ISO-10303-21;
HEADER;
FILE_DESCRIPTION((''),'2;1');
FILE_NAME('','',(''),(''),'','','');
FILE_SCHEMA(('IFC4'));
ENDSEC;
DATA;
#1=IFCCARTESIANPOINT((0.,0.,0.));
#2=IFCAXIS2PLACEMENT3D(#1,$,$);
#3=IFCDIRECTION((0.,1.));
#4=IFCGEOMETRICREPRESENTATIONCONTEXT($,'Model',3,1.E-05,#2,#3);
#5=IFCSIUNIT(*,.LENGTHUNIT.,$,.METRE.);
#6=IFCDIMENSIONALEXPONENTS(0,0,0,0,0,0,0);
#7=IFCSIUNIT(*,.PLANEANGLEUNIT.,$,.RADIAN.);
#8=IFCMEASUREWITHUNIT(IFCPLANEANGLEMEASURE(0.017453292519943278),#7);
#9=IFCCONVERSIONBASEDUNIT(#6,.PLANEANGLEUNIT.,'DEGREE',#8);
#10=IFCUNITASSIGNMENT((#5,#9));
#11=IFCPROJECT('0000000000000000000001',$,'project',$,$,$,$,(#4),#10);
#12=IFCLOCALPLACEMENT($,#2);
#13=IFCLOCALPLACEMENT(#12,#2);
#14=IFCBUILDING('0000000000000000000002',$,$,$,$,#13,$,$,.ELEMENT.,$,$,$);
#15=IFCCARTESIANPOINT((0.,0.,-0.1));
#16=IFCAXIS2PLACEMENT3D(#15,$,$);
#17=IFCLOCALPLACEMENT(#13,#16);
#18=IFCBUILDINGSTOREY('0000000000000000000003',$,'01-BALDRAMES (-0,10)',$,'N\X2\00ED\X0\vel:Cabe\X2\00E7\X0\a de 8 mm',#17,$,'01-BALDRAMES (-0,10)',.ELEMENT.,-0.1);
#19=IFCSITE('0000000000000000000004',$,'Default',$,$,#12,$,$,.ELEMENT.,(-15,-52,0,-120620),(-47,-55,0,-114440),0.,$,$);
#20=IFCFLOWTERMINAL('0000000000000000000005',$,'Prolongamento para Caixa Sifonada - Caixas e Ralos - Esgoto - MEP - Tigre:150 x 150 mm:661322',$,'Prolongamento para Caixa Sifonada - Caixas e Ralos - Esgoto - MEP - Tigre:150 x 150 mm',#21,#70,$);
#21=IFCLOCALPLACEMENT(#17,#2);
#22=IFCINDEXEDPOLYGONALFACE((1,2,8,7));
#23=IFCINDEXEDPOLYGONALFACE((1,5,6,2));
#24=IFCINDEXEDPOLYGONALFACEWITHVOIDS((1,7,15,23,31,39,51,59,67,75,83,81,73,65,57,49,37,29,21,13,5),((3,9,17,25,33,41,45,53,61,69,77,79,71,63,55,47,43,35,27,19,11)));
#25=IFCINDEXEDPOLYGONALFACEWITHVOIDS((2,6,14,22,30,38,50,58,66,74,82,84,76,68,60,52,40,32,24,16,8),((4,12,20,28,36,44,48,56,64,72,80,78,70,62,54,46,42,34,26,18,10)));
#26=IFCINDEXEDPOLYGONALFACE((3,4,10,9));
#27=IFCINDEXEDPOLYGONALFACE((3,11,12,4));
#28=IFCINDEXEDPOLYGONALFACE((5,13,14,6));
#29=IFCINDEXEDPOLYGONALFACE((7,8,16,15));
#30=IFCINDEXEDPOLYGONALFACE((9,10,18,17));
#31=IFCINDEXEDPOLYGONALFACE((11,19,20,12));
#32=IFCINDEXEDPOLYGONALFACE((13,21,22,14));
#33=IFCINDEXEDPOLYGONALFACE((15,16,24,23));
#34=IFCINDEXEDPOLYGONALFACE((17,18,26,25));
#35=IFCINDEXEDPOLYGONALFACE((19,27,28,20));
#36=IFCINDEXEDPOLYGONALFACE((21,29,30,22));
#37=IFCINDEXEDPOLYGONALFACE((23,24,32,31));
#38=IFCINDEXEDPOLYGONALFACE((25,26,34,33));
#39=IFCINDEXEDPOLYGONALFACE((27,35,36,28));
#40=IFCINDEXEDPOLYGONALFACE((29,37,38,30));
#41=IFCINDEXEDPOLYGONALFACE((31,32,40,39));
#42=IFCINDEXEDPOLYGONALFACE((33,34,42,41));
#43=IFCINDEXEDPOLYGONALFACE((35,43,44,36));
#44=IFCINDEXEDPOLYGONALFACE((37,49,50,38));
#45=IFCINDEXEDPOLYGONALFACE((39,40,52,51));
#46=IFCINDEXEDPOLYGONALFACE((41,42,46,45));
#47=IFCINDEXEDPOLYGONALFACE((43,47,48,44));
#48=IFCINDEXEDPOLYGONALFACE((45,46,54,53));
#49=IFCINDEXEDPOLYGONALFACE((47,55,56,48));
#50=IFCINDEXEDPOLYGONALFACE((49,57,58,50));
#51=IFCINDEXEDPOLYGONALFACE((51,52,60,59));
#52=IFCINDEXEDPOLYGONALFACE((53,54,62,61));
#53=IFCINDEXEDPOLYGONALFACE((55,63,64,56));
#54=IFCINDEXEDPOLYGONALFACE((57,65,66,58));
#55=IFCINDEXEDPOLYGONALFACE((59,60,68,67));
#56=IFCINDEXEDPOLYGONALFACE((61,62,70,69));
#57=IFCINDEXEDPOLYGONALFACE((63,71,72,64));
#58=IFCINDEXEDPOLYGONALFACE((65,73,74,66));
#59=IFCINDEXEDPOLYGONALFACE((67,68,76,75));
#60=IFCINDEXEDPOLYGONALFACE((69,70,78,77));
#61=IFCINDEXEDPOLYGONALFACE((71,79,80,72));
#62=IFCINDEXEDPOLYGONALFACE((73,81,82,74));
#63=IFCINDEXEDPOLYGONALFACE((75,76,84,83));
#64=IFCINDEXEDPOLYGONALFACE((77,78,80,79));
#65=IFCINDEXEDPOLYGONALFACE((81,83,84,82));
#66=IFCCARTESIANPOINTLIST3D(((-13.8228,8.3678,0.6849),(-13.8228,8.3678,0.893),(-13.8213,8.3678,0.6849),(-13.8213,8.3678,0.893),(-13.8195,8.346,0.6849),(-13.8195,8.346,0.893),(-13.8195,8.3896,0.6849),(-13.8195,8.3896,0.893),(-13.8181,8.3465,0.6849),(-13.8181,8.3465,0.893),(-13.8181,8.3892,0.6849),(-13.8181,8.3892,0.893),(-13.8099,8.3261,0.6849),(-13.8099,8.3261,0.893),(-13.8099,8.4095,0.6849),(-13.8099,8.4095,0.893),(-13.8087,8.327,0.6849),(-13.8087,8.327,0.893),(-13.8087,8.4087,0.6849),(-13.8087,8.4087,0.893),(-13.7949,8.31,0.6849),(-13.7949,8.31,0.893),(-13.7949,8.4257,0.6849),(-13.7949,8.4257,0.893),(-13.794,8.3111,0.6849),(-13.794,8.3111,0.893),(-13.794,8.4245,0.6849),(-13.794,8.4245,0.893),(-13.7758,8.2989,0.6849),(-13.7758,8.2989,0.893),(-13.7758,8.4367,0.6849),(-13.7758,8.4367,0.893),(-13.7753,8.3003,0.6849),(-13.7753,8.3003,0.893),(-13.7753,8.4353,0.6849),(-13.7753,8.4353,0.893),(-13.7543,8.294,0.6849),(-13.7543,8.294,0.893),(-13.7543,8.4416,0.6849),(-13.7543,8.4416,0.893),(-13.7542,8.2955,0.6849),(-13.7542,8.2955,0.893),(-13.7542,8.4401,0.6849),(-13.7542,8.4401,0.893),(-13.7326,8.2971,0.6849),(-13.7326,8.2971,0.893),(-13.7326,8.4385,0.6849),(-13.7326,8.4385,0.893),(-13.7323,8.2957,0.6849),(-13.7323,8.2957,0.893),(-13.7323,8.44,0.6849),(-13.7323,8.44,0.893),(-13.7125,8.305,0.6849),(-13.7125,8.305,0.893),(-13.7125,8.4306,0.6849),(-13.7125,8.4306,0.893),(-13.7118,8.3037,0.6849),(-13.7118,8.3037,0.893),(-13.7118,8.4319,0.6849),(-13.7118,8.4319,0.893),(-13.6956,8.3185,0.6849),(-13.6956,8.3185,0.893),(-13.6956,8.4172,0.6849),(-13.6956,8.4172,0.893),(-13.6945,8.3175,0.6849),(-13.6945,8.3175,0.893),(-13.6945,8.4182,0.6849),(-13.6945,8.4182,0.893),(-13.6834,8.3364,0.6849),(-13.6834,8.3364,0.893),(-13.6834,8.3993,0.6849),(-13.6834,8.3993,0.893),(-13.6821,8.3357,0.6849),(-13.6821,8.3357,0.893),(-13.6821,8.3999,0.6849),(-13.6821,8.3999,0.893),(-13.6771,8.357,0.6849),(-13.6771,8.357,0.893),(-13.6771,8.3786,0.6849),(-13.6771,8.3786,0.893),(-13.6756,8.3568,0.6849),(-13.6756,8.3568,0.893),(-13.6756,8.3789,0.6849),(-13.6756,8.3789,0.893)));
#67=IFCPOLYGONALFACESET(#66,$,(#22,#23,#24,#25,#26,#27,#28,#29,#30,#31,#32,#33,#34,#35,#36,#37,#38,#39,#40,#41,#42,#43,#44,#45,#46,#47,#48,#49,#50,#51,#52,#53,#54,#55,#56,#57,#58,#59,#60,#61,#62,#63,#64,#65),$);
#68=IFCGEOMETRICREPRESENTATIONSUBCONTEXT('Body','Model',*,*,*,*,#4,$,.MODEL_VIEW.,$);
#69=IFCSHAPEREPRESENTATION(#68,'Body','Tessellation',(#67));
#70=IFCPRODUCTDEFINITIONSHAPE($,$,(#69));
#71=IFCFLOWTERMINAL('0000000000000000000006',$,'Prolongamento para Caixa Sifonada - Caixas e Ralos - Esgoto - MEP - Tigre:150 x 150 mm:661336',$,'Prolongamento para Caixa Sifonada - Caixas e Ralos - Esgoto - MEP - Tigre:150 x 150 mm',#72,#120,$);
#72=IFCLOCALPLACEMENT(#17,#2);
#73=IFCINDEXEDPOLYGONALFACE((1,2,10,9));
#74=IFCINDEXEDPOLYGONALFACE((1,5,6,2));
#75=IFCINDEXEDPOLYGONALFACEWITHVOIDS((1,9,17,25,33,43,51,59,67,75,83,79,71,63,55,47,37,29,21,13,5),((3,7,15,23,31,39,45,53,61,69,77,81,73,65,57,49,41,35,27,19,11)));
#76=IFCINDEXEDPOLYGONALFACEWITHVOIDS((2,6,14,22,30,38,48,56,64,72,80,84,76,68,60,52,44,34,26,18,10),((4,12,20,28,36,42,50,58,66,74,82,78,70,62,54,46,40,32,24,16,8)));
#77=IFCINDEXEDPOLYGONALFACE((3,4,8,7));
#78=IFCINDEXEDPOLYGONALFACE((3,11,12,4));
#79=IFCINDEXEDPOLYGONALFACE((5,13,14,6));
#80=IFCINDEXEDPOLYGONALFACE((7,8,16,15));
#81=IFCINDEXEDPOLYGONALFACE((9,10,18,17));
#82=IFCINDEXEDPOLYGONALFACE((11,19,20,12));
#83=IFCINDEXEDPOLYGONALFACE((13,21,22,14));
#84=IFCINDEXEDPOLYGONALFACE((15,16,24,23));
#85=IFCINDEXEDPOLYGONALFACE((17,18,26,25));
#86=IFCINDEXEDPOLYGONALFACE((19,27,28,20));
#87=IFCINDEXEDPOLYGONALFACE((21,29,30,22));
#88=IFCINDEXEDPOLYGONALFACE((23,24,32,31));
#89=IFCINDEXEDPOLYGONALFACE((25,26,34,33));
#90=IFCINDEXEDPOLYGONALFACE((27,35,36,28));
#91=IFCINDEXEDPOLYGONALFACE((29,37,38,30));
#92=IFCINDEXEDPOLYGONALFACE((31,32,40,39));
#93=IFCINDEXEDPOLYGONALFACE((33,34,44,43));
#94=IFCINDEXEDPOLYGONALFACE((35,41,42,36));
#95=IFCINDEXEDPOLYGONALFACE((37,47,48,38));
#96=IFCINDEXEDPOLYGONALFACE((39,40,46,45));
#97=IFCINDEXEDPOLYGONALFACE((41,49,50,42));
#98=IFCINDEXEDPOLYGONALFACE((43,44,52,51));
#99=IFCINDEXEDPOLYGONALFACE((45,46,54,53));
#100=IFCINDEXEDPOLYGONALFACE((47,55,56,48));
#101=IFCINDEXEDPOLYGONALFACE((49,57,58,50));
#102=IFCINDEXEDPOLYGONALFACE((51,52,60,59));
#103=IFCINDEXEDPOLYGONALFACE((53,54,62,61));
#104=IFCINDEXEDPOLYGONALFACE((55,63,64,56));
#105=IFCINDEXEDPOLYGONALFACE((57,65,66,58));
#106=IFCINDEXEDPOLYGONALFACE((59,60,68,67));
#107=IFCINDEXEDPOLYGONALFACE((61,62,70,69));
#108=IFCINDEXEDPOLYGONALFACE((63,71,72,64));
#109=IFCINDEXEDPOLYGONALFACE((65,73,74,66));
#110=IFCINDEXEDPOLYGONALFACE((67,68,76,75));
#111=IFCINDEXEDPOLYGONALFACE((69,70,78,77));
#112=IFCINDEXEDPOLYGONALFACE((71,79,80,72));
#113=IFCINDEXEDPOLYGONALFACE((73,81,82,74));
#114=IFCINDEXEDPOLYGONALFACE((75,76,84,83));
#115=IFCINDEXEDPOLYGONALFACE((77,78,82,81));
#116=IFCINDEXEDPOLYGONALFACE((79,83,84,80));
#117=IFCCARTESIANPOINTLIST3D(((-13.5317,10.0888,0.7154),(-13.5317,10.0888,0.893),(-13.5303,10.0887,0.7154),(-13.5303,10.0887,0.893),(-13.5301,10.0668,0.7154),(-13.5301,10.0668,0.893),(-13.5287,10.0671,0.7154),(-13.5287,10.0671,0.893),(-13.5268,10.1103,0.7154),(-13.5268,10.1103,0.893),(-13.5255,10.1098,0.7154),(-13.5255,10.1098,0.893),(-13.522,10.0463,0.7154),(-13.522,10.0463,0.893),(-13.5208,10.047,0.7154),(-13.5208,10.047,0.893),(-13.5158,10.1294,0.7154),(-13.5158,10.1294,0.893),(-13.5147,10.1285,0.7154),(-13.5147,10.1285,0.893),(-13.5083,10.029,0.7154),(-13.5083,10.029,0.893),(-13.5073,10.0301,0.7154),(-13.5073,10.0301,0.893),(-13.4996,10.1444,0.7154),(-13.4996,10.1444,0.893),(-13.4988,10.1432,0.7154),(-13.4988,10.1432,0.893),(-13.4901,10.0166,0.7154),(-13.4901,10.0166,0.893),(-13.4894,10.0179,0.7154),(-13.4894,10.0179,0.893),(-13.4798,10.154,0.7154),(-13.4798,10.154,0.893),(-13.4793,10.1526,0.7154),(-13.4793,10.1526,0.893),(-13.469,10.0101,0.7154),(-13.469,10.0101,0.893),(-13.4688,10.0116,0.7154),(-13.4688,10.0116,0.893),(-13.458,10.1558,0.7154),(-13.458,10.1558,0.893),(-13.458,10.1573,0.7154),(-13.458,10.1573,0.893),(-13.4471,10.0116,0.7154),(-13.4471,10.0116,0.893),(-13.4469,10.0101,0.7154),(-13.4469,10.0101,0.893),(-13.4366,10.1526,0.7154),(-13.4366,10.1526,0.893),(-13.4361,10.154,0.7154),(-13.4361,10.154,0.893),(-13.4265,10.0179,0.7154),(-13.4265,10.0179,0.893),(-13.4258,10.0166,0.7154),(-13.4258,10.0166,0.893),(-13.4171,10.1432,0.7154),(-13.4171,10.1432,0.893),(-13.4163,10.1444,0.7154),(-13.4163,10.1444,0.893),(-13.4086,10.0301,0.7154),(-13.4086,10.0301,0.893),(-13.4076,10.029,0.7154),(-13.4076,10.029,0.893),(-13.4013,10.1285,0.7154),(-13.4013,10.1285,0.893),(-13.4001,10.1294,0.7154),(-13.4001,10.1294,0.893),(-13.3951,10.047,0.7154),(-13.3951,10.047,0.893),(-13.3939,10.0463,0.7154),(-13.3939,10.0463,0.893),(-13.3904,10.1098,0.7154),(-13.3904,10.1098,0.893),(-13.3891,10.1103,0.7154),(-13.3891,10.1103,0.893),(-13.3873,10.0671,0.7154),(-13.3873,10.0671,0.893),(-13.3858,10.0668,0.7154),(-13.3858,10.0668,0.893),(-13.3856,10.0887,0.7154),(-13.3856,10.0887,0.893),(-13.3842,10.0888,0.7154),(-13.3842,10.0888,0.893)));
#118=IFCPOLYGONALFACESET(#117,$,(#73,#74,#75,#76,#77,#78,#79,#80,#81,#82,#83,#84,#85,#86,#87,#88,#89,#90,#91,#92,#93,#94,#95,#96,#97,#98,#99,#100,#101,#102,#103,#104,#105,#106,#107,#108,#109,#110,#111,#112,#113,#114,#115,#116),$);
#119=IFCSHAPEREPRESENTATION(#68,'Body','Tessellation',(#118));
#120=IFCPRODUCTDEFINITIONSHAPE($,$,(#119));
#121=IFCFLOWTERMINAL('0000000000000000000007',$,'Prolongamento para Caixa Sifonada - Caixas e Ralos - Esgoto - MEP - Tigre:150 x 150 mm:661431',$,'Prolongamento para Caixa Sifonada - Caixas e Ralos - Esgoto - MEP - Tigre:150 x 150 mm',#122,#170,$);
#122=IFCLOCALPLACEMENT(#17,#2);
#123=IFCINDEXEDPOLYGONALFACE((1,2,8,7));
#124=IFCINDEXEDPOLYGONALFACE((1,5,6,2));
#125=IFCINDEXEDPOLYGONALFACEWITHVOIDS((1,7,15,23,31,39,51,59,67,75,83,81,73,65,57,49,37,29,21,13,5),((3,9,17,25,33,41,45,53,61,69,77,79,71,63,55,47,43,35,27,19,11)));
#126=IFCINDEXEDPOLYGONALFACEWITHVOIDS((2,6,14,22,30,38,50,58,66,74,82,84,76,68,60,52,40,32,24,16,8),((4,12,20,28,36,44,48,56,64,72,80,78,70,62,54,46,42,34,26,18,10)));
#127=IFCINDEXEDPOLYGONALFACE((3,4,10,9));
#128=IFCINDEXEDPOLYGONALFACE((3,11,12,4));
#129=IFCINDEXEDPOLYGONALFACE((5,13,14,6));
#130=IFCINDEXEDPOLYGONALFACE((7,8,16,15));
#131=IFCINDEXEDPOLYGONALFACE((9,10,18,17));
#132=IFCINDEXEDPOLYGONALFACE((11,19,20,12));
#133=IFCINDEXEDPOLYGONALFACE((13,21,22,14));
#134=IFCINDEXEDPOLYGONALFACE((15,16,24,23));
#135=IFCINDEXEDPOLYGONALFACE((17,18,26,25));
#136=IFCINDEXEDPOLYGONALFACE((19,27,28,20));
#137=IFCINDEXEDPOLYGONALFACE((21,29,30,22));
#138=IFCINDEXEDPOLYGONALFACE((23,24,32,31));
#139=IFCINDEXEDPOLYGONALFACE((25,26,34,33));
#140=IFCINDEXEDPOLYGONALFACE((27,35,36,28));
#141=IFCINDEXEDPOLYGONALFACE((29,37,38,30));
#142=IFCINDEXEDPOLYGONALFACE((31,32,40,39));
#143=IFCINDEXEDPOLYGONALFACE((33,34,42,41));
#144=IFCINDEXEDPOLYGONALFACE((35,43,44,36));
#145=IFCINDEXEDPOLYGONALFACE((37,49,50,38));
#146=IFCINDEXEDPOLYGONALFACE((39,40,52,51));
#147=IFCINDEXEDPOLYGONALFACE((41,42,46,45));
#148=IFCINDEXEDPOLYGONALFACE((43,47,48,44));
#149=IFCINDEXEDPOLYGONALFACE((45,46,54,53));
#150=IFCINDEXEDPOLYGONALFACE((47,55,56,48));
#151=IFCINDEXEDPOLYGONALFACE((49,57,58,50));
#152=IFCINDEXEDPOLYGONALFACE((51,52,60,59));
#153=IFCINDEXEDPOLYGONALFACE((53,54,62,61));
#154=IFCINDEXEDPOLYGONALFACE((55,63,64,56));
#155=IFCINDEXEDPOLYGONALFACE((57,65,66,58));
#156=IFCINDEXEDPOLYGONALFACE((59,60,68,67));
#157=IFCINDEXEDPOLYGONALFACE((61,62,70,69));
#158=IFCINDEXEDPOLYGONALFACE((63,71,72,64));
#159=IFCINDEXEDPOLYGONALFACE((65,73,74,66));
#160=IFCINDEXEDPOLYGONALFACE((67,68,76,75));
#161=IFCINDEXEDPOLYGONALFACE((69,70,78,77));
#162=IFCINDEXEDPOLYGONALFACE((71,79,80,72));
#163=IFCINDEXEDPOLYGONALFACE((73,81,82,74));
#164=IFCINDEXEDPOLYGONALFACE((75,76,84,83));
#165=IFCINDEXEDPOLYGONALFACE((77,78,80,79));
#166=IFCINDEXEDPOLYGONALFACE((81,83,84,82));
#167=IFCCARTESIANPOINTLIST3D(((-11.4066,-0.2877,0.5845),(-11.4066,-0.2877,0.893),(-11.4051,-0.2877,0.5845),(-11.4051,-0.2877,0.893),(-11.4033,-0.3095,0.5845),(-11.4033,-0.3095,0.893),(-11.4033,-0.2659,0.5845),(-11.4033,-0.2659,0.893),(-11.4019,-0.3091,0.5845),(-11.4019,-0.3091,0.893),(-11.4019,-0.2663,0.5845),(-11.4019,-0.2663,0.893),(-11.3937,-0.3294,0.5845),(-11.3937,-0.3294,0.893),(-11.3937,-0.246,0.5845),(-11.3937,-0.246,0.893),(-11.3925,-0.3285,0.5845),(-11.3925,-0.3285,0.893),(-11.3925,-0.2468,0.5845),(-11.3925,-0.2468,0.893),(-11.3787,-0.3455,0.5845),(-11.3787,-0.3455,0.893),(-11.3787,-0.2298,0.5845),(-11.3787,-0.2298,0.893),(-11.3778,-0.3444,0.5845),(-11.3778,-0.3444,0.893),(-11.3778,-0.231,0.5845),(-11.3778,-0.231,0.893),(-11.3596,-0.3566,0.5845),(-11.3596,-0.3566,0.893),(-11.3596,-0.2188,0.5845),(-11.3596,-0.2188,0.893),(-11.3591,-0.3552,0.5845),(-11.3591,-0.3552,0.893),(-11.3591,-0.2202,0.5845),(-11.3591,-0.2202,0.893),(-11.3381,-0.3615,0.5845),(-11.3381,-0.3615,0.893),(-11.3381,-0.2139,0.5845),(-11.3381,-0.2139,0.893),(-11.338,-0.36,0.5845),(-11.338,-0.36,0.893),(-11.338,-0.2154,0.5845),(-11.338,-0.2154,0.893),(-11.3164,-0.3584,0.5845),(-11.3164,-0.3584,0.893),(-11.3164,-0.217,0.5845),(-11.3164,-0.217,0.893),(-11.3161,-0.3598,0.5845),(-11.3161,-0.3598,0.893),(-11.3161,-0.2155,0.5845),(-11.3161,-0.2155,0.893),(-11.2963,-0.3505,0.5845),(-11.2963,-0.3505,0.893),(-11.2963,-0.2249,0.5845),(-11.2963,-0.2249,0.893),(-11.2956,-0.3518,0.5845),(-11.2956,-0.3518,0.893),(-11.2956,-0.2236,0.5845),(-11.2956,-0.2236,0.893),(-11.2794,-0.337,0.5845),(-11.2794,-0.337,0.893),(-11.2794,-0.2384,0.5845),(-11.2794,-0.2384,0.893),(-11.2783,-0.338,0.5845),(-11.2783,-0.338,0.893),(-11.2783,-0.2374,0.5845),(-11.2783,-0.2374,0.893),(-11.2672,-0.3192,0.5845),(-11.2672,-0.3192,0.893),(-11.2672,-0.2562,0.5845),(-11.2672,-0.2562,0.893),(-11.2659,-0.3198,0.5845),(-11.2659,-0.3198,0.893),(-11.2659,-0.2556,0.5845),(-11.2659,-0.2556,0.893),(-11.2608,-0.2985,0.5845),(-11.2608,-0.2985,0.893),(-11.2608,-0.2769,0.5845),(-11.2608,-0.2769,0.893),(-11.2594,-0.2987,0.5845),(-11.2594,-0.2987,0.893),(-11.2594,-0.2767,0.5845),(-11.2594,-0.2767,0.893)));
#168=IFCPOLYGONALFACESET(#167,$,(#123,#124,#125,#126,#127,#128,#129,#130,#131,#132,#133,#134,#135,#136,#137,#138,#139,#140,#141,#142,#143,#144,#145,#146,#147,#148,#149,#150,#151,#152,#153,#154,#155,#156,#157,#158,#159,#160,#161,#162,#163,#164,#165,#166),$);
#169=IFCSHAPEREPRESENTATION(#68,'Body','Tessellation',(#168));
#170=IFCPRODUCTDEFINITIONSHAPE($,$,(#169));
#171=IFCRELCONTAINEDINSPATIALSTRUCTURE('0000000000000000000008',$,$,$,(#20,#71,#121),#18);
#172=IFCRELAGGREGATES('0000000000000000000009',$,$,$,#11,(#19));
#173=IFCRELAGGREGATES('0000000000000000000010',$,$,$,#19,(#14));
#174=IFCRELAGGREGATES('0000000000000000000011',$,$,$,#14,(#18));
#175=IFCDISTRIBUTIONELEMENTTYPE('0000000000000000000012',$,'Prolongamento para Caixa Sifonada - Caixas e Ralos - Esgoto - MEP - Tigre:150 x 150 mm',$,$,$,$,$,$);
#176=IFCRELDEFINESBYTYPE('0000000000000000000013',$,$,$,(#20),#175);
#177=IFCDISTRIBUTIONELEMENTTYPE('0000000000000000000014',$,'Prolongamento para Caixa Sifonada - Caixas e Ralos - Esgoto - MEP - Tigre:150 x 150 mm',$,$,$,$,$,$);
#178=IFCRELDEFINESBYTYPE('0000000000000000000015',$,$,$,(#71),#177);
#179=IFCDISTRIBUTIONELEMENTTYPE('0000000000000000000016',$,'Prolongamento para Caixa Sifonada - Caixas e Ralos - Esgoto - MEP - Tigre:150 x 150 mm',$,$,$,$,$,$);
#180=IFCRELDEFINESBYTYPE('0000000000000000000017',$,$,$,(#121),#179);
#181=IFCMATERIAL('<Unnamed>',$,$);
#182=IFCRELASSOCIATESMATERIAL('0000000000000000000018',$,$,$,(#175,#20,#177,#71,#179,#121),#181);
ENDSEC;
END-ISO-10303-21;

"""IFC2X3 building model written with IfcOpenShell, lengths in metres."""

from ifc_helpers import new_model, entity, si_unit, converted_unit, direction, frame, frame_2d, origin, place, context, subcontext, project, spatial, hollow_circle, extrude, source, transform, mapped, material, type_object, type_shapes, element, save


model = new_model("IFC2X3")

# Units and contexts
model_context = context("Model", 3, precision=1e-05, world=origin(), true_north=direction((0.0, 1.0)))
body_context = subcontext(model_context, "Body", "Model", "MODEL_VIEW")
ifc_project = project(units=[si_unit("LENGTHUNIT", "METRE"), converted_unit("PLANEANGLEUNIT", "DEGREE", entity("IfcPlaneAngleMeasure", 0.017453292519943278), si_unit("PLANEANGLEUNIT", "RADIAN"), dimensions=[0, 0, 0, 0, 0, 0, 0])], contexts=[model_context])

# Site, building, storey
site_placement = place(None, origin())
site = spatial("IfcSite", under=ifc_project, at=site_placement, Name="Default", CompositionType="ELEMENT", RefLatitude=(-15, -52, 0, -120620), RefLongitude=(-47, -55, 0, -114440), RefElevation=0.0)
building_placement = place(site_placement, origin())
building = spatial("IfcBuilding", under=site, at=building_placement, CompositionType="ELEMENT")
storey_placement = place(building_placement, frame((0.0, 0.0, -0.1)))
storey = spatial("IfcBuildingStorey", under=building, at=storey_placement, Name="01-BALDRAMES (-0,10)", ObjectType="Nível:Cabeça de 8 mm", LongName="01-BALDRAMES (-0,10)", CompositionType="ELEMENT", Elevation=-0.1)

# Flow terminals
ifc_material = material(Name="<Unnamed>")
distribution_element_type_1 = type_object("IfcDistributionElementType", Name="Prolongamento para Caixa Sifonada - Caixas e Ralos - Esgoto - MEP - Tigre:150 x 150 mm", material=ifc_material)
shared_shape_1 = source(origin(), body_context, "Body", "SweptSolid", [
    extrude(hollow_circle(Radius=0.074, WallThickness=0.0015, at=frame_2d((0.0, 0.0), x_axis=(1.0, 0.0))), frame((0.0, 0.0, -0.2081)), (0.0, 0.0, 1.0), 0.2081),
])
type_shapes(distribution_element_type_1, [shared_shape_1])
flow_terminal_1_placement = place(storey_placement, frame((-13.7488, 8.3678, 0.893), z_axis=(0.0, 0.0, 1.0), x_axis=(-1.0, -0.000001, 0.0)))
element("IfcFlowTerminal", 1, at=flow_terminal_1_placement, inside=storey, type_object=distribution_element_type_1, material=ifc_material, Name="Prolongamento para Caixa Sifonada - Caixas e Ralos - Esgoto - MEP - Tigre:150 x 150 mm:661322", ObjectType="Prolongamento para Caixa Sifonada - Caixas e Ralos - Esgoto - MEP - Tigre:150 x 150 mm", context=body_context, shape_type="MappedRepresentation", body=[
    mapped(shared_shape_1, transform((0.0, 0.0, 0.0), scale=1.0)),
])
distribution_element_type_2 = type_object("IfcDistributionElementType", Name="Prolongamento para Caixa Sifonada - Caixas e Ralos - Esgoto - MEP - Tigre:150 x 150 mm", material=ifc_material)
shared_shape_2 = source(origin(), body_context, "Body", "SweptSolid", [
    extrude(hollow_circle(Radius=0.074, WallThickness=0.0015, at=frame_2d((0.0, 0.0), x_axis=(1.0, 0.0))), frame((0.0, 0.0, -0.1776)), (0.0, 0.0, 1.0), 0.1776),
])
type_shapes(distribution_element_type_2, [shared_shape_2])
flow_terminal_2_placement = place(storey_placement, frame((-13.458, 10.0833, 0.893), z_axis=(0.0, 0.0, 1.0), x_axis=(-0.000001, 1.0, 0.0)))
element("IfcFlowTerminal", 2, at=flow_terminal_2_placement, inside=storey, type_object=distribution_element_type_2, material=ifc_material, Name="Prolongamento para Caixa Sifonada - Caixas e Ralos - Esgoto - MEP - Tigre:150 x 150 mm:661336", ObjectType="Prolongamento para Caixa Sifonada - Caixas e Ralos - Esgoto - MEP - Tigre:150 x 150 mm", context=body_context, shape_type="MappedRepresentation", body=[
    mapped(shared_shape_2, transform((0.0, 0.0, 0.0), scale=1.0)),
])
distribution_element_type_3 = type_object("IfcDistributionElementType", Name="Prolongamento para Caixa Sifonada - Caixas e Ralos - Esgoto - MEP - Tigre:150 x 150 mm", material=ifc_material)
shared_shape_3 = source(origin(), body_context, "Body", "SweptSolid", [
    extrude(hollow_circle(Radius=0.074, WallThickness=0.0015, at=frame_2d((0.0, 0.0), x_axis=(1.0, 0.0))), frame((0.0, 0.0, -0.3085)), (0.0, 0.0, 1.0), 0.3085),
])
type_shapes(distribution_element_type_3, [shared_shape_3])
flow_terminal_3_placement = place(storey_placement, frame((-11.3326, -0.2877, 0.893), z_axis=(0.0, 0.0, 1.0), x_axis=(-1.0, -0.000001, 0.0)))
element("IfcFlowTerminal", 3, at=flow_terminal_3_placement, inside=storey, type_object=distribution_element_type_3, material=ifc_material, Name="Prolongamento para Caixa Sifonada - Caixas e Ralos - Esgoto - MEP - Tigre:150 x 150 mm:661431", ObjectType="Prolongamento para Caixa Sifonada - Caixas e Ralos - Esgoto - MEP - Tigre:150 x 150 mm", context=body_context, shape_type="MappedRepresentation", body=[
    mapped(shared_shape_3, transform((0.0, 0.0, 0.0), scale=1.0)),
])

save(model, "model.ifc")
